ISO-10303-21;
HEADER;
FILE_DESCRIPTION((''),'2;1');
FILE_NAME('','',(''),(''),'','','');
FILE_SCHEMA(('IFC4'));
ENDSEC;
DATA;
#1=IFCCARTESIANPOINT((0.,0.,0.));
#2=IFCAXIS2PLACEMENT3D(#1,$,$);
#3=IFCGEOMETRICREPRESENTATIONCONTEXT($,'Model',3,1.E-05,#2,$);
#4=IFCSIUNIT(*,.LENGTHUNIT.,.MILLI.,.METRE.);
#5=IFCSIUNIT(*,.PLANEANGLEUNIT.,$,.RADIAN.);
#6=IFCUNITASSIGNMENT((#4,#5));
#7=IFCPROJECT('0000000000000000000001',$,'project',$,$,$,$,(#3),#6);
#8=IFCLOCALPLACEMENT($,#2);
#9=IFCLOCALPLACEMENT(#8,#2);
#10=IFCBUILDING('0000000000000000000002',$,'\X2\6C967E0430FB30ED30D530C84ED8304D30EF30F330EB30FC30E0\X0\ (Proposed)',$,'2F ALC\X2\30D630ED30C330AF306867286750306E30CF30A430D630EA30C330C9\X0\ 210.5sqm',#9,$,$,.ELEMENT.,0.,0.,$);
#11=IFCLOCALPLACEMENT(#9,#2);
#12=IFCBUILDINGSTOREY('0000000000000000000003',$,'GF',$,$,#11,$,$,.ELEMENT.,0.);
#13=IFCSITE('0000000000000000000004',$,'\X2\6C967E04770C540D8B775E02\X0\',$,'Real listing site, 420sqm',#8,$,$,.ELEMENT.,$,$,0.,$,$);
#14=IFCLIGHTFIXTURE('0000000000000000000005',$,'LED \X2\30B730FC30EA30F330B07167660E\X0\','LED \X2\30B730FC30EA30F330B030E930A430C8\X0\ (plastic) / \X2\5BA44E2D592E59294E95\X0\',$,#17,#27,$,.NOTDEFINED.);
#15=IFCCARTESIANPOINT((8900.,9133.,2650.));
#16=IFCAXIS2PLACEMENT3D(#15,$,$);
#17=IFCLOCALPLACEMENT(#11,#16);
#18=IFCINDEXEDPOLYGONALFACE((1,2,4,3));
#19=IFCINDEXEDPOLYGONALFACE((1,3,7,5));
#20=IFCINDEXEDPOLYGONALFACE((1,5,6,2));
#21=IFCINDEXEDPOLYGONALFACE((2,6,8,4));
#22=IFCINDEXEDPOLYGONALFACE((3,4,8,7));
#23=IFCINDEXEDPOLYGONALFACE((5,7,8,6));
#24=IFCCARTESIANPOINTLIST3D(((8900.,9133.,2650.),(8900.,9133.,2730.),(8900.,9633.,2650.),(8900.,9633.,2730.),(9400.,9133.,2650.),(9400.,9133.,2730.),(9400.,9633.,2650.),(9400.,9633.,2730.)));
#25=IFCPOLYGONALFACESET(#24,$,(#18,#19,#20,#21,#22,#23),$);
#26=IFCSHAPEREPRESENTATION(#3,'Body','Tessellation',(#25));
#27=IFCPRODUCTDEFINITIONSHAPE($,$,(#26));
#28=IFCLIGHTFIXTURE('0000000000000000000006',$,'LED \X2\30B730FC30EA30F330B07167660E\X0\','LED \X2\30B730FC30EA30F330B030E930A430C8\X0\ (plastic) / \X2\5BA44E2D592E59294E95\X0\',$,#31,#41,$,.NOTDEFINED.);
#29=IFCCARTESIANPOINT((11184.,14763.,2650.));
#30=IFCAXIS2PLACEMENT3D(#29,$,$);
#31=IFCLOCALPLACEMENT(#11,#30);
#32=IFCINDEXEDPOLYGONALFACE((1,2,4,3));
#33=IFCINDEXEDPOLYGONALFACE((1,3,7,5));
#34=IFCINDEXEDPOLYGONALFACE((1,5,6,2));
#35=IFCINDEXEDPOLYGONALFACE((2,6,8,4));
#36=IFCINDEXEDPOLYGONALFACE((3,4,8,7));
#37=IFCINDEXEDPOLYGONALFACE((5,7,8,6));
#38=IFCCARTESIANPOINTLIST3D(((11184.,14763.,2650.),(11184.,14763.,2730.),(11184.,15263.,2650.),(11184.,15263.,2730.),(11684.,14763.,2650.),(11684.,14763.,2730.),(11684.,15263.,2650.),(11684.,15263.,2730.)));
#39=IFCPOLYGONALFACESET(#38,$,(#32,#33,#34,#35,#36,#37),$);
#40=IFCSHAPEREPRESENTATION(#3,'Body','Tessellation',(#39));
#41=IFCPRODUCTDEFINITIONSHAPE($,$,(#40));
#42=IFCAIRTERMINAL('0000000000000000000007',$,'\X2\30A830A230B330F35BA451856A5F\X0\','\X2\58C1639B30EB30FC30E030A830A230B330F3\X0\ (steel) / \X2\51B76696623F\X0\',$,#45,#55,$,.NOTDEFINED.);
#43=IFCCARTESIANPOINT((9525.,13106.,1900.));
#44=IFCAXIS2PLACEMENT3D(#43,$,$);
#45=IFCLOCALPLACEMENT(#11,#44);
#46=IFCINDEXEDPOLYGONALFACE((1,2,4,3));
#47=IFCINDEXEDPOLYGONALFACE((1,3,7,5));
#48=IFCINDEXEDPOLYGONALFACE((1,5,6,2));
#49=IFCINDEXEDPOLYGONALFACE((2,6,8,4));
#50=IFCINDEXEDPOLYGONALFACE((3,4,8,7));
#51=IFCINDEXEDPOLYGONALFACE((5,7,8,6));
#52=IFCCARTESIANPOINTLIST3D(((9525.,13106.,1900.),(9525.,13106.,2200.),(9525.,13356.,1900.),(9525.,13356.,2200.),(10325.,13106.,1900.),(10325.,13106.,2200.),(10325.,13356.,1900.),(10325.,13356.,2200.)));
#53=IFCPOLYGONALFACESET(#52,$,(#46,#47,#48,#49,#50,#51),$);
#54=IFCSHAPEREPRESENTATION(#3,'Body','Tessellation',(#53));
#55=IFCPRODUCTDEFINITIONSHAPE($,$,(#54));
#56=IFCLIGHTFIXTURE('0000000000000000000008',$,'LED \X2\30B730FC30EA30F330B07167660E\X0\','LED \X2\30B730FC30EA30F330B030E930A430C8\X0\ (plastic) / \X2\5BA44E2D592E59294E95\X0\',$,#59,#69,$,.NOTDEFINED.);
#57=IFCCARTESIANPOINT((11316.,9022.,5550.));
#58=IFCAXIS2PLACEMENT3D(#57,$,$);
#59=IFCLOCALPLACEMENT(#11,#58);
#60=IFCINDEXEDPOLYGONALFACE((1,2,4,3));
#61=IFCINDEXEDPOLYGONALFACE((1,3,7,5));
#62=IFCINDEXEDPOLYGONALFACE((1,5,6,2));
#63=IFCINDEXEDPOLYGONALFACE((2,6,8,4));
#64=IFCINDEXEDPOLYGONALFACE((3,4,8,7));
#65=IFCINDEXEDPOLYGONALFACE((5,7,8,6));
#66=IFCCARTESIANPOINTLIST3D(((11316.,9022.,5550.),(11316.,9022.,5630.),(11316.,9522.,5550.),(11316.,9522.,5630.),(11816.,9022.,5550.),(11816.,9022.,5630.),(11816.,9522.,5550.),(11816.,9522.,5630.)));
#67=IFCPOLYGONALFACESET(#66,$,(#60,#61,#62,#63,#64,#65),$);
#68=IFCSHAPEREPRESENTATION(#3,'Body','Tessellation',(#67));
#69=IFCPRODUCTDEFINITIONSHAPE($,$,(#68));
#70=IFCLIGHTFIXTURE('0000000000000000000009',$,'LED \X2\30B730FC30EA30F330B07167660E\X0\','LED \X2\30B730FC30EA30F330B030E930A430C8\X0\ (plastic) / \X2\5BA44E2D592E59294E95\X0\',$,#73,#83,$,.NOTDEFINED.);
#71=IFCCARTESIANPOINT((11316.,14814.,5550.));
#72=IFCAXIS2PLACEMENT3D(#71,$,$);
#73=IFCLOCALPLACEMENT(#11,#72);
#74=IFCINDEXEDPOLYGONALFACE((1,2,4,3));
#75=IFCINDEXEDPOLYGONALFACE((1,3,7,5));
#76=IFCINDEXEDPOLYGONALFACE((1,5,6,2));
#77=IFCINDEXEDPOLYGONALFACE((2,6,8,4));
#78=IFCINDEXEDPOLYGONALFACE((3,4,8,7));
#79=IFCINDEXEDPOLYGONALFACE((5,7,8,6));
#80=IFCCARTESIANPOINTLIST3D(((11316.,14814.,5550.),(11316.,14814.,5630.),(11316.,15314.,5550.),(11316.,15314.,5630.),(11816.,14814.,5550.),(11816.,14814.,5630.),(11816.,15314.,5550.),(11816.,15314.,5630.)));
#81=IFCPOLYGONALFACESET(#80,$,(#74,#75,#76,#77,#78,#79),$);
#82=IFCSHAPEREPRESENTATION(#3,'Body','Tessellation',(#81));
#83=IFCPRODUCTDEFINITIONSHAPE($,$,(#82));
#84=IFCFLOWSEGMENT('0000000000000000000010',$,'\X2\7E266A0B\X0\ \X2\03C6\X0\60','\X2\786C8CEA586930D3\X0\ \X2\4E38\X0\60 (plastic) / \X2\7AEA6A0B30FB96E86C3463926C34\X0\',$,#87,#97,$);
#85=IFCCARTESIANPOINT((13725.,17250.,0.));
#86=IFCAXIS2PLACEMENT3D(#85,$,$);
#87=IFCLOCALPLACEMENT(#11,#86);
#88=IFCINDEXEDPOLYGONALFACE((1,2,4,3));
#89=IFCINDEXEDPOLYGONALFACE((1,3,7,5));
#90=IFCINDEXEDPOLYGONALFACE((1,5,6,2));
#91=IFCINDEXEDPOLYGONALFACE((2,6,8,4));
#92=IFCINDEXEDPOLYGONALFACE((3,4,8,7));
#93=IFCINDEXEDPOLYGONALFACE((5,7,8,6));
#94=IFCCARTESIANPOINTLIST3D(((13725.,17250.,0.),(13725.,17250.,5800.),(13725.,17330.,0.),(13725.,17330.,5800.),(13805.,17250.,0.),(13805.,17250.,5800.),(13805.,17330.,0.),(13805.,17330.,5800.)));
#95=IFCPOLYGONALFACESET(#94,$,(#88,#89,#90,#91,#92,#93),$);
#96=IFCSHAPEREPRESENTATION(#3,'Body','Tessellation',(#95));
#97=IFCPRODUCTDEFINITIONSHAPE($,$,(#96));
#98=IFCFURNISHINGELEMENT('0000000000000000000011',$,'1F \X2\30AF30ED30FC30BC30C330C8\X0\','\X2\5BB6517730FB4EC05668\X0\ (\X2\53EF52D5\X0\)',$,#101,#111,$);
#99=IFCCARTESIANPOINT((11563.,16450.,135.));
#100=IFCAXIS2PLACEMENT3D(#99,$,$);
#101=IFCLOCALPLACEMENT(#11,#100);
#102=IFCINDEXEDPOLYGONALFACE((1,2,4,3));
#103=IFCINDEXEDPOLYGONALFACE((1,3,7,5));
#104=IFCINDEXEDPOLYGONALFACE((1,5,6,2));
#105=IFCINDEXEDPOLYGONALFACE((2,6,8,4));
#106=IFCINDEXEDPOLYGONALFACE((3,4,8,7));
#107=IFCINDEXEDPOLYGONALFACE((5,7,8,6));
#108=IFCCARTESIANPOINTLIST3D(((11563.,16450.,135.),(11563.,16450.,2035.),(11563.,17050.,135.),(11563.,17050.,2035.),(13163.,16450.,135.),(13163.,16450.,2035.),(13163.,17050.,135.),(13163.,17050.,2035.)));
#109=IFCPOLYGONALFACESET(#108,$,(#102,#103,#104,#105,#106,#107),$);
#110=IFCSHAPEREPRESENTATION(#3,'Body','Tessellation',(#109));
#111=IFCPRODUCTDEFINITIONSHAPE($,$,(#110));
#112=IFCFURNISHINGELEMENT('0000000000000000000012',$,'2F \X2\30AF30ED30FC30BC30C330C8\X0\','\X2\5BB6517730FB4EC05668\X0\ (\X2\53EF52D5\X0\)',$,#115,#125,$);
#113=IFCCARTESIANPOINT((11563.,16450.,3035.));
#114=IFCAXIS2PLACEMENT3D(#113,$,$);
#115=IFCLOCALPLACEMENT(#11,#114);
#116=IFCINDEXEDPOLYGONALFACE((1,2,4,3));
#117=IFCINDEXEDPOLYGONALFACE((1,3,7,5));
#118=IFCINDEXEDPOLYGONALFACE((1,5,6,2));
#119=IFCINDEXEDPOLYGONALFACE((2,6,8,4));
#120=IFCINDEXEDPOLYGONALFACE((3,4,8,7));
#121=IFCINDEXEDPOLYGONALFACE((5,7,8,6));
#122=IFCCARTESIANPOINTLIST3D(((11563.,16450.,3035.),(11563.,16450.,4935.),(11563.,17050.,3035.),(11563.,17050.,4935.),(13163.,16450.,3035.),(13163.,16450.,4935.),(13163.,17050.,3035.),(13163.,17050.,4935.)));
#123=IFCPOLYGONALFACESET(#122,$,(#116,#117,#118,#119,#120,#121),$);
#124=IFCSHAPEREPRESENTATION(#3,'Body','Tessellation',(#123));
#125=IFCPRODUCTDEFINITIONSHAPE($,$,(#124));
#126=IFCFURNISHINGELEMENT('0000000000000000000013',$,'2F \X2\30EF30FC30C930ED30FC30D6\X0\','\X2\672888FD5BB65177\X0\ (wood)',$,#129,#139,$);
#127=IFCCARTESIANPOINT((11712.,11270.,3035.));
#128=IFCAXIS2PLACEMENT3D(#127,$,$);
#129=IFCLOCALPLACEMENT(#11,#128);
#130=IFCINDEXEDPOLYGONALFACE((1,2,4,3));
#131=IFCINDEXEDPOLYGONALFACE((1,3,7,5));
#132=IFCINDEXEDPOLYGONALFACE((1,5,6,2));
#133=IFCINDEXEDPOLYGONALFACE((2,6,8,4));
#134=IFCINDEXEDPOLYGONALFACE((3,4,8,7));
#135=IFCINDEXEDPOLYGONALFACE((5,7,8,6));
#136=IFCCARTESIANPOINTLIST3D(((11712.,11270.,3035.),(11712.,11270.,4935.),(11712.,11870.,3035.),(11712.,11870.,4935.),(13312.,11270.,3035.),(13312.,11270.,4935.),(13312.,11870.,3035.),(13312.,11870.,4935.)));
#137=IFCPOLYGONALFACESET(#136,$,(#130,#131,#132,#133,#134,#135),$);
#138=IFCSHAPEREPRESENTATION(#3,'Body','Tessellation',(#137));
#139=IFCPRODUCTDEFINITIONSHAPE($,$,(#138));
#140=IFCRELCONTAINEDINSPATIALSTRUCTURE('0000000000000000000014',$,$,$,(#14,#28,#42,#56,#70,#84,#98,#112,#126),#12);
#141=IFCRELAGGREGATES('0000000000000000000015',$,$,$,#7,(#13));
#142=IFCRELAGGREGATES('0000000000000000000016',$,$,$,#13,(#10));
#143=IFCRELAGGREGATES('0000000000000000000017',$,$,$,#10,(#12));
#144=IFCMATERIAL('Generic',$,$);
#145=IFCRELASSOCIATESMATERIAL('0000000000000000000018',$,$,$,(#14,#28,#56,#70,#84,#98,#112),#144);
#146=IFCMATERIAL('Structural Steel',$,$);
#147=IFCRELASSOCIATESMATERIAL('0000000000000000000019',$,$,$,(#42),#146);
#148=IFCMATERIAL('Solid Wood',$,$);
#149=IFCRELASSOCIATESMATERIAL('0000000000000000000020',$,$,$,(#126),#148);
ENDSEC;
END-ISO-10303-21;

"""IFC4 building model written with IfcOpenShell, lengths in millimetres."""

from ifc_helpers import new_model, si_unit, frame, frame_2d, origin, place, context, project, spatial, rectangle, extrude, material, element, save


model = new_model("IFC4")

# Units and contexts
model_context = context("Model", 3, precision=1e-05, world=origin())
ifc_project = project(units=[si_unit("LENGTHUNIT", "METRE", prefix="MILLI"), si_unit("PLANEANGLEUNIT", "RADIAN")], contexts=[model_context])

# Site, building, storey
site_placement = place(None, origin())
site = spatial("IfcSite", under=ifc_project, at=site_placement, Name="沖縄県名護市", ObjectType="Real listing site, 420sqm", CompositionType="ELEMENT", RefElevation=0.0)
building_placement = place(site_placement, origin())
building = spatial("IfcBuilding", under=site, at=building_placement, Name="沖縄・ロフト付きワンルーム (Proposed)", ObjectType="2F ALCブロックと木材のハイブリッド 210.5sqm", CompositionType="ELEMENT", ElevationOfRefHeight=0.0, ElevationOfTerrain=0.0)
storey_placement = place(building_placement, origin())
storey = spatial("IfcBuildingStorey", under=building, at=storey_placement, Name="GF", CompositionType="ELEMENT", Elevation=0.0)

# Shared definitions
ifc_material_1 = material(Name="Solid Wood")

# Shared definitions
ifc_material_2 = material(Name="Structural Steel")

# Shared definitions
ifc_material_3 = material(Name="Generic")

# Light fixtures
light_fixture_1_placement = place(storey_placement, frame((8900.0, 9133.0, 2650.0)))
element("IfcLightFixture", 1, at=light_fixture_1_placement, inside=storey, material=ifc_material_3, Name="LED シーリング照明", Description="LED シーリングライト (plastic) / 室中央天井", PredefinedType="NOTDEFINED", context=model_context, shape_type="SweptSolid", body=[
    extrude(rectangle(XDim=500.0, YDim=500.0, at=frame_2d((250.0, 250.0))), frame((8900.0, 9133.0, 2650.0)), (0.0, 0.0, 1.0), 80.0),
])
light_fixture_2_placement = place(storey_placement, frame((11184.0, 14763.0, 2650.0)))
element("IfcLightFixture", 2, at=light_fixture_2_placement, inside=storey, material=ifc_material_3, Name="LED シーリング照明", Description="LED シーリングライト (plastic) / 室中央天井", PredefinedType="NOTDEFINED", context=model_context, shape_type="SweptSolid", body=[
    extrude(rectangle(XDim=500.0, YDim=500.0, at=frame_2d((250.0, 250.0))), frame((11184.0, 14763.0, 2650.0)), (0.0, 0.0, 1.0), 80.0),
])

# Air terminal
air_terminal_placement = place(storey_placement, frame((9525.0, 13106.0, 1900.0)))
element("IfcAirTerminal", 3, at=air_terminal_placement, inside=storey, material=ifc_material_2, Name="エアコン室内機", Description="壁掛ルームエアコン (steel) / 冷暖房", PredefinedType="NOTDEFINED", context=model_context, shape_type="SweptSolid", body=[
    extrude(rectangle(XDim=800.0, YDim=250.0, at=frame_2d((400.0, 125.0))), frame((9525.0, 13106.0, 1900.0)), (0.0, 0.0, 1.0), 300.0),
])

# Light fixtures
light_fixture_3_placement = place(storey_placement, frame((11316.0, 9022.0, 5550.0)))
element("IfcLightFixture", 4, at=light_fixture_3_placement, inside=storey, material=ifc_material_3, Name="LED シーリング照明", Description="LED シーリングライト (plastic) / 室中央天井", PredefinedType="NOTDEFINED", context=model_context, shape_type="SweptSolid", body=[
    extrude(rectangle(XDim=500.0, YDim=500.0, at=frame_2d((250.0, 250.0))), frame((11316.0, 9022.0, 5550.0)), (0.0, 0.0, 1.0), 80.0),
])
light_fixture_4_placement = place(storey_placement, frame((11316.0, 14814.0, 5550.0)))
element("IfcLightFixture", 5, at=light_fixture_4_placement, inside=storey, material=ifc_material_3, Name="LED シーリング照明", Description="LED シーリングライト (plastic) / 室中央天井", PredefinedType="NOTDEFINED", context=model_context, shape_type="SweptSolid", body=[
    extrude(rectangle(XDim=500.0, YDim=500.0, at=frame_2d((250.0, 250.0))), frame((11316.0, 14814.0, 5550.0)), (0.0, 0.0, 1.0), 80.0),
])

# Flow segment
flow_segment_placement = place(storey_placement, frame((13725.0, 17250.0, 0.0)))
element("IfcFlowSegment", 6, at=flow_segment_placement, inside=storey, material=ifc_material_3, Name="縦樋 φ60", Description="硬質塩ビ 丸60 (plastic) / 竪樋・雨水排水", context=model_context, shape_type="SweptSolid", body=[
    extrude(rectangle(XDim=80.0, YDim=80.0, at=frame_2d((40.0, 40.0))), frame((13725.0, 17250.0, 0.0)), (0.0, 0.0, 1.0), 5800.0),
])

# Furnishing elements
furnishing_1_placement = place(storey_placement, frame((11563.0, 16450.0, 135.0)))
element("IfcFurnishingElement", 7, at=furnishing_1_placement, inside=storey, material=ifc_material_3, Name="1F クローゼット", Description="家具・什器 (可動)", context=model_context, shape_type="SweptSolid", body=[
    extrude(rectangle(XDim=1600.0, YDim=600.0, at=frame_2d((800.0, 300.0))), frame((11563.0, 16450.0, 135.0)), (0.0, 0.0, 1.0), 1900.0),
])
furnishing_2_placement = place(storey_placement, frame((11563.0, 16450.0, 3035.0)))
element("IfcFurnishingElement", 8, at=furnishing_2_placement, inside=storey, material=ifc_material_3, Name="2F クローゼット", Description="家具・什器 (可動)", context=model_context, shape_type="SweptSolid", body=[
    extrude(rectangle(XDim=1600.0, YDim=600.0, at=frame_2d((800.0, 300.0))), frame((11563.0, 16450.0, 3035.0)), (0.0, 0.0, 1.0), 1900.0),
])
furnishing_3_placement = place(storey_placement, frame((11712.0, 11270.0, 3035.0)))
element("IfcFurnishingElement", 9, at=furnishing_3_placement, inside=storey, material=ifc_material_1, Name="2F ワードローブ", Description="木製家具 (wood)", context=model_context, shape_type="SweptSolid", body=[
    extrude(rectangle(XDim=1600.0, YDim=600.0, at=frame_2d((800.0, 300.0))), frame((11712.0, 11270.0, 3035.0)), (0.0, 0.0, 1.0), 1900.0),
])

save(model, "model.ifc")
